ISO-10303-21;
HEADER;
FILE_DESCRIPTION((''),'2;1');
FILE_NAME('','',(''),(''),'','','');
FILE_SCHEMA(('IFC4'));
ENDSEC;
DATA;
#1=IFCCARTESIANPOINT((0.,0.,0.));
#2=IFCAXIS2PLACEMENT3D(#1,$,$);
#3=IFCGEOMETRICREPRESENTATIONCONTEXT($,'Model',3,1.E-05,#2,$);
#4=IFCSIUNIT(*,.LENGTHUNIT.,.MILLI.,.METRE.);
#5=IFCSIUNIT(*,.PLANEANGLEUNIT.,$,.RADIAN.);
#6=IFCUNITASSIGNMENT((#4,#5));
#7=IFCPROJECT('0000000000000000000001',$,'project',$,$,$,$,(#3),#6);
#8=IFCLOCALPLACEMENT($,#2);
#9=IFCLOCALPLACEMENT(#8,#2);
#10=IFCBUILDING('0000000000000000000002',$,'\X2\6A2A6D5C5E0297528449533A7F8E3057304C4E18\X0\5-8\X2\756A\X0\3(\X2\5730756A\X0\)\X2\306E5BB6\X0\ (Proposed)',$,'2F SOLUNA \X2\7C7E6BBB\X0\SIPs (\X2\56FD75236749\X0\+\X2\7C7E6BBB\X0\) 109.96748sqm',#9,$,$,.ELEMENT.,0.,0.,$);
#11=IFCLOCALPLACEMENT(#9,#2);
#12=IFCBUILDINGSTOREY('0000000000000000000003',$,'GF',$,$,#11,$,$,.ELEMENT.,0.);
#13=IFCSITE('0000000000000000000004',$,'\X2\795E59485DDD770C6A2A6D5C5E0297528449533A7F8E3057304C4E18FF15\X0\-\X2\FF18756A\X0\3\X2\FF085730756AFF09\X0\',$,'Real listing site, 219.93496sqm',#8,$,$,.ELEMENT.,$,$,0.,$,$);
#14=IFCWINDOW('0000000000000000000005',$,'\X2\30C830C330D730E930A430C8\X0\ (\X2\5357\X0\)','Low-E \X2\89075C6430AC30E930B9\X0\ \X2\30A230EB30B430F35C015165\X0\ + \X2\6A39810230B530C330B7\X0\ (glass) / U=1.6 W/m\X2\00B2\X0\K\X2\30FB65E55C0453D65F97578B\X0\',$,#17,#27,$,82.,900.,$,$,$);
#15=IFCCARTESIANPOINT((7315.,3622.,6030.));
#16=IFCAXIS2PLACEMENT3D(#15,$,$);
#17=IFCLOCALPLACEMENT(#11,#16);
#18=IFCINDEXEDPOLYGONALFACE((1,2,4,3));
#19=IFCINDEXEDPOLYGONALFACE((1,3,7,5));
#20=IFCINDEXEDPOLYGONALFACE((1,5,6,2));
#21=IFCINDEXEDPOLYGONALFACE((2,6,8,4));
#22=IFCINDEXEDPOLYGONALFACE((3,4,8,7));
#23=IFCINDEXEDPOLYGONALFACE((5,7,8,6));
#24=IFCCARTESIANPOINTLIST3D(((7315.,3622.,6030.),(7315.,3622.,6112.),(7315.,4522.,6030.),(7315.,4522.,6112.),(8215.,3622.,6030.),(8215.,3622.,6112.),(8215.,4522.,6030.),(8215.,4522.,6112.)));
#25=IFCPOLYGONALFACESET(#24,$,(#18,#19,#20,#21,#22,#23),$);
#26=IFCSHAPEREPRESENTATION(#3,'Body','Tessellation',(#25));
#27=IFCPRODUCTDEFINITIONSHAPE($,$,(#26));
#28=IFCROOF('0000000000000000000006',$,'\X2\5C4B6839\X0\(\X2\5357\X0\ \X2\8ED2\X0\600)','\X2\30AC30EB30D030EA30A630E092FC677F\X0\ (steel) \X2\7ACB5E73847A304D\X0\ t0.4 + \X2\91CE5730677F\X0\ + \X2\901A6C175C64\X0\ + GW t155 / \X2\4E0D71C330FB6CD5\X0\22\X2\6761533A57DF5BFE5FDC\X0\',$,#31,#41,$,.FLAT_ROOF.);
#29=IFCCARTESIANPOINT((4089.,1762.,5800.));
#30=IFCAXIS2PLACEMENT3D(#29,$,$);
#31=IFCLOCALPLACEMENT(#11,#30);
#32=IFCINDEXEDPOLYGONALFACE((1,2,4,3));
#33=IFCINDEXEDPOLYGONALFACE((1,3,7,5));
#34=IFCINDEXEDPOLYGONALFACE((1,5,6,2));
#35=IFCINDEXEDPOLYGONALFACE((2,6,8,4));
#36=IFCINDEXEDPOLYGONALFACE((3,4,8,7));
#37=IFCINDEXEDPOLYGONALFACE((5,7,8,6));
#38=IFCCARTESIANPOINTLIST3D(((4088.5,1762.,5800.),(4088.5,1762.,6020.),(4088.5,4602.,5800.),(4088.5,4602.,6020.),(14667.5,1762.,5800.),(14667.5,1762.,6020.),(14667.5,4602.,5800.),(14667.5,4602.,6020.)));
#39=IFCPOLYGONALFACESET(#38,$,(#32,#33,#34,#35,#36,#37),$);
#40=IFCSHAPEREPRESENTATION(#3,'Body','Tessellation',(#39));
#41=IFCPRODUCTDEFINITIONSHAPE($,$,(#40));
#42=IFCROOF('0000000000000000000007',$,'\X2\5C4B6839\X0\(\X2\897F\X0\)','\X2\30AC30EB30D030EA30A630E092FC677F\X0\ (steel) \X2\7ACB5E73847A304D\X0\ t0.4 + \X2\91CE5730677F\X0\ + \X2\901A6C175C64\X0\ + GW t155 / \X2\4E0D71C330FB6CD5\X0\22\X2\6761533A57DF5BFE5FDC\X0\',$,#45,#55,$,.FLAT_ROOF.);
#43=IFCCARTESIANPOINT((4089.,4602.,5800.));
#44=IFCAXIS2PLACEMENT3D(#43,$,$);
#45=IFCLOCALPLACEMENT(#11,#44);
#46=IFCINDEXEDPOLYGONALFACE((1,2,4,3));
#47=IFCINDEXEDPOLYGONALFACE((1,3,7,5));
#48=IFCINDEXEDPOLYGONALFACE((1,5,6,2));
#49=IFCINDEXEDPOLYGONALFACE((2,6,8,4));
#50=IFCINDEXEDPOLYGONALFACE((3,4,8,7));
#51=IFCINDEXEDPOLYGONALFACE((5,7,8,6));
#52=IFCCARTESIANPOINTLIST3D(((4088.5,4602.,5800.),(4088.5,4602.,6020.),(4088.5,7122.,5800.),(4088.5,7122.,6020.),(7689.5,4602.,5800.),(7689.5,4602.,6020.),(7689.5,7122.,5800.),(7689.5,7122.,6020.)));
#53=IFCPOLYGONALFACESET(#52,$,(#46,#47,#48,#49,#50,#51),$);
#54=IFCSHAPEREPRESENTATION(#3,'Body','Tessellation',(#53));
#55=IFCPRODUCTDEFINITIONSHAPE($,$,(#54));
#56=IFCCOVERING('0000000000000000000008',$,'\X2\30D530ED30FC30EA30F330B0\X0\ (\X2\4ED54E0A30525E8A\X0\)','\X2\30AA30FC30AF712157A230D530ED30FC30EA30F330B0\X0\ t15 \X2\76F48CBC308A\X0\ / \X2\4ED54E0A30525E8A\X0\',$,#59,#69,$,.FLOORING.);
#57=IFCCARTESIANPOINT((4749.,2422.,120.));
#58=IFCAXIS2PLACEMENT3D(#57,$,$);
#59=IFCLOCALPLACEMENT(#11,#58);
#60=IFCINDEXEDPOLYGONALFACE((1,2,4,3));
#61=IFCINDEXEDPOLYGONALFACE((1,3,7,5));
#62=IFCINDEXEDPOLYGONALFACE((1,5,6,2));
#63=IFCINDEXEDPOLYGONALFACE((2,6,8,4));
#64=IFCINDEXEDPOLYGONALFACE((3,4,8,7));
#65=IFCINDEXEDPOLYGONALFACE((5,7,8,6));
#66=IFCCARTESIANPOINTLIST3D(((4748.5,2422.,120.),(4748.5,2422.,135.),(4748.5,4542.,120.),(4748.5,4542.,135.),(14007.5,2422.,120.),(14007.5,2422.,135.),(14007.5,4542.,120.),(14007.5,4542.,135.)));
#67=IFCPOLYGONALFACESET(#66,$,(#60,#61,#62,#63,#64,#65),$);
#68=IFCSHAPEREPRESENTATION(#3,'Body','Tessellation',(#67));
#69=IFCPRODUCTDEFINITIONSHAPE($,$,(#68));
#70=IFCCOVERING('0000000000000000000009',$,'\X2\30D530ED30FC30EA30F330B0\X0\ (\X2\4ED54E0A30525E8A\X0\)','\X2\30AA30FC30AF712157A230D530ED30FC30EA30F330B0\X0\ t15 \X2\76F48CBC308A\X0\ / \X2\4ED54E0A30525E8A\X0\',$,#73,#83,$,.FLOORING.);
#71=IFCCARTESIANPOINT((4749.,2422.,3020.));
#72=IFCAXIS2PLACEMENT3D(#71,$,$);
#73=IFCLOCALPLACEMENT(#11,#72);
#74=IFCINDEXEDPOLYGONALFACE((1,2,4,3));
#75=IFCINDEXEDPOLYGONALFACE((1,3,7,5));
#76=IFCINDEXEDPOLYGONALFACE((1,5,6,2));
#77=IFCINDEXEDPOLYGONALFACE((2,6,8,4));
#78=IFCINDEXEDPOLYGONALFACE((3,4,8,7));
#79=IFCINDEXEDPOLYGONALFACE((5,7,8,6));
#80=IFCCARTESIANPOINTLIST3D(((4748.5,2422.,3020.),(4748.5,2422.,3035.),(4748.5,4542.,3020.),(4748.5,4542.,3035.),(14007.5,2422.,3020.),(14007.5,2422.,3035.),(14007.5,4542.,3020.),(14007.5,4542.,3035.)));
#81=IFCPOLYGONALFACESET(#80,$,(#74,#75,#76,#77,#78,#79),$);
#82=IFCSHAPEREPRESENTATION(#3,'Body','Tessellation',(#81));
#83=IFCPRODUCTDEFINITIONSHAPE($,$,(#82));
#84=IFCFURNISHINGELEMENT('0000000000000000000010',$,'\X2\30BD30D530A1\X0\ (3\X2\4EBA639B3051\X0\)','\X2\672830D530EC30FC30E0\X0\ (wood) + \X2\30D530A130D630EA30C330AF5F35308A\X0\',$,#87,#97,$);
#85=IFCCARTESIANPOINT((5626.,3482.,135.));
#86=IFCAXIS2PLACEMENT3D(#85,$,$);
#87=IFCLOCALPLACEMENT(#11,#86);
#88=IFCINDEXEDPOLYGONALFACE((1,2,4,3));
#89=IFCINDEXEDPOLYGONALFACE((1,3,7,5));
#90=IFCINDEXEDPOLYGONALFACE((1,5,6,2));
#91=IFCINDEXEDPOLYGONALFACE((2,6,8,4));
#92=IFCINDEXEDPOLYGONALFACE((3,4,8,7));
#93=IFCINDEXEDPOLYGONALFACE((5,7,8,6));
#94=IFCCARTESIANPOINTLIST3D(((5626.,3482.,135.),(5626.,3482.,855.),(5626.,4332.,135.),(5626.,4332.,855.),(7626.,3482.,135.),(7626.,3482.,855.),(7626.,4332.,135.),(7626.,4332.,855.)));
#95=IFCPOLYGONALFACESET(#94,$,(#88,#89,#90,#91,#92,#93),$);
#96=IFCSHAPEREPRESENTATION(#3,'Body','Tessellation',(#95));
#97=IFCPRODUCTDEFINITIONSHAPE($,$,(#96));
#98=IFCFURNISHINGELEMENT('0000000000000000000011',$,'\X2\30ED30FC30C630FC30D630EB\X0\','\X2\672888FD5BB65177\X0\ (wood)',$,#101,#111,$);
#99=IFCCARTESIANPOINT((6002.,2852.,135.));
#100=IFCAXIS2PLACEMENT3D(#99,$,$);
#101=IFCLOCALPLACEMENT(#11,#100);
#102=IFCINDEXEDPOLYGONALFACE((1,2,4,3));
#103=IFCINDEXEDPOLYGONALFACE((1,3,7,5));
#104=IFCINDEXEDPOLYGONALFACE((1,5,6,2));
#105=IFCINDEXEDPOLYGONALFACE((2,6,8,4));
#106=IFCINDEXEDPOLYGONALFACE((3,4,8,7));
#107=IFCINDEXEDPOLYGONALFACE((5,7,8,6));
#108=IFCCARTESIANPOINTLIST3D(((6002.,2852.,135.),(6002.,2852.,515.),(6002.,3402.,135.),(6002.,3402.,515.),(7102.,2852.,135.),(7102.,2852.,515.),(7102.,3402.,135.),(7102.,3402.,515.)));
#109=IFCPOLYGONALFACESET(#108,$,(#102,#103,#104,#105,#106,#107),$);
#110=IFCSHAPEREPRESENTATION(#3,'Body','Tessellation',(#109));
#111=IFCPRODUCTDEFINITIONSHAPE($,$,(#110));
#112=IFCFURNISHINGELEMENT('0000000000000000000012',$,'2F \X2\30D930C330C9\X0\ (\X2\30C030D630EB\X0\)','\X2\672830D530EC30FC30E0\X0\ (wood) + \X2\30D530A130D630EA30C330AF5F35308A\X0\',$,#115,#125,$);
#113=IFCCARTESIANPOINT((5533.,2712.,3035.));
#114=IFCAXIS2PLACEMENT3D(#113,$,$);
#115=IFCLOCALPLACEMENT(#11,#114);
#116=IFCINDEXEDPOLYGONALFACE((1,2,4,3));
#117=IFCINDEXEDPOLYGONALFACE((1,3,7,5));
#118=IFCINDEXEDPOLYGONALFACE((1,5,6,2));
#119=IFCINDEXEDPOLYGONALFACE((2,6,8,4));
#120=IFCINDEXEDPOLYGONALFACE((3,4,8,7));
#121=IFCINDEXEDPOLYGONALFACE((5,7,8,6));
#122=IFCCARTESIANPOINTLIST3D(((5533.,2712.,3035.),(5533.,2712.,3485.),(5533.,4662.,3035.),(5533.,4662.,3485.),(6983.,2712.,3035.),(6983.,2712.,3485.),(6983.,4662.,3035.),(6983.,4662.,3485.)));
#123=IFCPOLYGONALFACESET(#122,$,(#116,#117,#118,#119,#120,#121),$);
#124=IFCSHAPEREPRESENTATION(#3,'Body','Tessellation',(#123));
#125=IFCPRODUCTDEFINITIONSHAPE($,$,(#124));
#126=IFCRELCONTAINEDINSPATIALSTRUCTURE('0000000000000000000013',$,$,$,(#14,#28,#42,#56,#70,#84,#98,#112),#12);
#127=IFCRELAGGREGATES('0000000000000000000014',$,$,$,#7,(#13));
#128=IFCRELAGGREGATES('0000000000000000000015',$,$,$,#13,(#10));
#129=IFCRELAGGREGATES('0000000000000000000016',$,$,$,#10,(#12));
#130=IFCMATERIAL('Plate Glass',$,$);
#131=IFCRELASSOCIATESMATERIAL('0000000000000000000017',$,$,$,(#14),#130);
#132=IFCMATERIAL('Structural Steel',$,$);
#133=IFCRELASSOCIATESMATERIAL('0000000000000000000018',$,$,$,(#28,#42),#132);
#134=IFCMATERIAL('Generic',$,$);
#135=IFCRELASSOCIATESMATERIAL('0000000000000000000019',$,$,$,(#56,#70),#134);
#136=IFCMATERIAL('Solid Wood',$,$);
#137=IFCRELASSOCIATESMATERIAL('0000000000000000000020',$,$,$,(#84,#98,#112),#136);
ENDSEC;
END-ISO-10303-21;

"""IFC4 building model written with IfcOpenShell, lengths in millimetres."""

from ifc_helpers import new_model, si_unit, frame, frame_2d, origin, place, context, project, spatial, rectangle, extrude, material, element, save


model = new_model("IFC4")

# Units and contexts
model_context = context("Model", 3, precision=1e-05, world=origin())
ifc_project = project(units=[si_unit("LENGTHUNIT", "METRE", prefix="MILLI"), si_unit("PLANEANGLEUNIT", "RADIAN")], contexts=[model_context])

# Site, building, storey
site_placement = place(None, origin())
site = spatial("IfcSite", under=ifc_project, at=site_placement, Name="神奈川県横浜市青葉区美しが丘５-８番3（地番）", ObjectType="Real listing site, 219.93496sqm", CompositionType="ELEMENT", RefElevation=0.0)
building_placement = place(site_placement, origin())
building = spatial("IfcBuilding", under=site, at=building_placement, Name="横浜市青葉区美しが丘5-8番3(地番)の家 (Proposed)", ObjectType="2F SOLUNA 籾殻SIPs (国産杉+籾殻) 109.96748sqm", CompositionType="ELEMENT", ElevationOfRefHeight=0.0, ElevationOfTerrain=0.0)
storey_placement = place(building_placement, origin())
storey = spatial("IfcBuildingStorey", under=building, at=storey_placement, Name="GF", CompositionType="ELEMENT", Elevation=0.0)

# Shared definitions
ifc_material_1 = material(Name="Solid Wood")

# Shared definitions
ifc_material_2 = material(Name="Plate Glass")

# Window
window_1_placement = place(storey_placement, frame((7315.0, 3622.0, 6030.0)))
element("IfcWindow", 1, at=window_1_placement, inside=storey, material=ifc_material_2, Name="トップライト (南)", Description="Low-E 複層ガラス アルゴン封入 + 樹脂サッシ (glass) / U=1.6 W/m²K・日射取得型", OverallHeight=82.0, OverallWidth=900.0, context=model_context, shape_type="SweptSolid", body=[
    extrude(rectangle(XDim=900.0, YDim=900.0, at=frame_2d((450.0, 450.0))), frame((7315.0, 3622.0, 6030.0)), (0.0, 0.0, 1.0), 82.0),
])

# Roofs
ifc_material_3 = material(Name="Structural Steel")
roof_1_placement = place(storey_placement, frame((4089.0, 1762.0, 5800.0)))
element("IfcRoof", 2, at=roof_1_placement, inside=storey, material=ifc_material_3, Name="屋根(南 軒600)", Description="ガルバリウム鋼板 (steel) 立平葺き t0.4 + 野地板 + 通気層 + GW t155 / 不燃・法22条区域対応", PredefinedType="FLAT_ROOF", context=model_context, shape_type="SweptSolid", body=[
    extrude(rectangle(XDim=10579.0, YDim=2840.0, at=frame_2d((5289.0, 1420.0))), frame((4089.0, 1762.0, 5800.0)), (0.0, 0.0, 1.0), 220.0),
])
roof_2_placement = place(storey_placement, frame((4089.0, 4602.0, 5800.0)))
element("IfcRoof", 3, at=roof_2_placement, inside=storey, material=ifc_material_3, Name="屋根(西)", Description="ガルバリウム鋼板 (steel) 立平葺き t0.4 + 野地板 + 通気層 + GW t155 / 不燃・法22条区域対応", PredefinedType="FLAT_ROOF", context=model_context, shape_type="SweptSolid", body=[
    extrude(rectangle(XDim=3601.0, YDim=2520.0, at=frame_2d((1800.0, 1260.0))), frame((4089.0, 4602.0, 5800.0)), (0.0, 0.0, 1.0), 220.0),
])

# Coverings
ifc_material_4 = material(Name="Generic")
covering_1_placement = place(storey_placement, frame((4749.0, 2422.0, 120.0)))
element("IfcCovering", 4, at=covering_1_placement, inside=storey, material=ifc_material_4, Name="フローリング (仕上げ床)", Description="オーク無垢フローリング t15 直貼り / 仕上げ床", PredefinedType="FLOORING", context=model_context, shape_type="SweptSolid", body=[
    extrude(rectangle(XDim=9259.0, YDim=2120.0, at=frame_2d((4629.0, 1060.0))), frame((4749.0, 2422.0, 120.0)), (0.0, 0.0, 1.0), 15.0),
])
covering_2_placement = place(storey_placement, frame((4749.0, 2422.0, 3020.0)))
element("IfcCovering", 5, at=covering_2_placement, inside=storey, material=ifc_material_4, Name="フローリング (仕上げ床)", Description="オーク無垢フローリング t15 直貼り / 仕上げ床", PredefinedType="FLOORING", context=model_context, shape_type="SweptSolid", body=[
    extrude(rectangle(XDim=9259.0, YDim=2120.0, at=frame_2d((4629.0, 1060.0))), frame((4749.0, 2422.0, 3020.0)), (0.0, 0.0, 1.0), 15.0),
])

# Furnishing elements
furnishing_1_placement = place(storey_placement, frame((5626.0, 3482.0, 135.0)))
element("IfcFurnishingElement", 6, at=furnishing_1_placement, inside=storey, material=ifc_material_1, Name="ソファ (3人掛け)", Description="木フレーム (wood) + ファブリック張り", context=model_context, shape_type="SweptSolid", body=[
    extrude(rectangle(XDim=2000.0, YDim=850.0, at=frame_2d((1000.0, 425.0))), frame((5626.0, 3482.0, 135.0)), (0.0, 0.0, 1.0), 720.0),
])
furnishing_2_placement = place(storey_placement, frame((6002.0, 2852.0, 135.0)))
element("IfcFurnishingElement", 7, at=furnishing_2_placement, inside=storey, material=ifc_material_1, Name="ローテーブル", Description="木製家具 (wood)", context=model_context, shape_type="SweptSolid", body=[
    extrude(rectangle(XDim=1100.0, YDim=550.0, at=frame_2d((550.0, 275.0))), frame((6002.0, 2852.0, 135.0)), (0.0, 0.0, 1.0), 380.0),
])
furnishing_3_placement = place(storey_placement, frame((5533.0, 2712.0, 3035.0)))
element("IfcFurnishingElement", 8, at=furnishing_3_placement, inside=storey, material=ifc_material_1, Name="2F ベッド (ダブル)", Description="木フレーム (wood) + ファブリック張り", context=model_context, shape_type="SweptSolid", body=[
    extrude(rectangle(XDim=1450.0, YDim=1950.0, at=frame_2d((725.0, 975.0))), frame((5533.0, 2712.0, 3035.0)), (0.0, 0.0, 1.0), 450.0),
])

save(model, "model.ifc")
